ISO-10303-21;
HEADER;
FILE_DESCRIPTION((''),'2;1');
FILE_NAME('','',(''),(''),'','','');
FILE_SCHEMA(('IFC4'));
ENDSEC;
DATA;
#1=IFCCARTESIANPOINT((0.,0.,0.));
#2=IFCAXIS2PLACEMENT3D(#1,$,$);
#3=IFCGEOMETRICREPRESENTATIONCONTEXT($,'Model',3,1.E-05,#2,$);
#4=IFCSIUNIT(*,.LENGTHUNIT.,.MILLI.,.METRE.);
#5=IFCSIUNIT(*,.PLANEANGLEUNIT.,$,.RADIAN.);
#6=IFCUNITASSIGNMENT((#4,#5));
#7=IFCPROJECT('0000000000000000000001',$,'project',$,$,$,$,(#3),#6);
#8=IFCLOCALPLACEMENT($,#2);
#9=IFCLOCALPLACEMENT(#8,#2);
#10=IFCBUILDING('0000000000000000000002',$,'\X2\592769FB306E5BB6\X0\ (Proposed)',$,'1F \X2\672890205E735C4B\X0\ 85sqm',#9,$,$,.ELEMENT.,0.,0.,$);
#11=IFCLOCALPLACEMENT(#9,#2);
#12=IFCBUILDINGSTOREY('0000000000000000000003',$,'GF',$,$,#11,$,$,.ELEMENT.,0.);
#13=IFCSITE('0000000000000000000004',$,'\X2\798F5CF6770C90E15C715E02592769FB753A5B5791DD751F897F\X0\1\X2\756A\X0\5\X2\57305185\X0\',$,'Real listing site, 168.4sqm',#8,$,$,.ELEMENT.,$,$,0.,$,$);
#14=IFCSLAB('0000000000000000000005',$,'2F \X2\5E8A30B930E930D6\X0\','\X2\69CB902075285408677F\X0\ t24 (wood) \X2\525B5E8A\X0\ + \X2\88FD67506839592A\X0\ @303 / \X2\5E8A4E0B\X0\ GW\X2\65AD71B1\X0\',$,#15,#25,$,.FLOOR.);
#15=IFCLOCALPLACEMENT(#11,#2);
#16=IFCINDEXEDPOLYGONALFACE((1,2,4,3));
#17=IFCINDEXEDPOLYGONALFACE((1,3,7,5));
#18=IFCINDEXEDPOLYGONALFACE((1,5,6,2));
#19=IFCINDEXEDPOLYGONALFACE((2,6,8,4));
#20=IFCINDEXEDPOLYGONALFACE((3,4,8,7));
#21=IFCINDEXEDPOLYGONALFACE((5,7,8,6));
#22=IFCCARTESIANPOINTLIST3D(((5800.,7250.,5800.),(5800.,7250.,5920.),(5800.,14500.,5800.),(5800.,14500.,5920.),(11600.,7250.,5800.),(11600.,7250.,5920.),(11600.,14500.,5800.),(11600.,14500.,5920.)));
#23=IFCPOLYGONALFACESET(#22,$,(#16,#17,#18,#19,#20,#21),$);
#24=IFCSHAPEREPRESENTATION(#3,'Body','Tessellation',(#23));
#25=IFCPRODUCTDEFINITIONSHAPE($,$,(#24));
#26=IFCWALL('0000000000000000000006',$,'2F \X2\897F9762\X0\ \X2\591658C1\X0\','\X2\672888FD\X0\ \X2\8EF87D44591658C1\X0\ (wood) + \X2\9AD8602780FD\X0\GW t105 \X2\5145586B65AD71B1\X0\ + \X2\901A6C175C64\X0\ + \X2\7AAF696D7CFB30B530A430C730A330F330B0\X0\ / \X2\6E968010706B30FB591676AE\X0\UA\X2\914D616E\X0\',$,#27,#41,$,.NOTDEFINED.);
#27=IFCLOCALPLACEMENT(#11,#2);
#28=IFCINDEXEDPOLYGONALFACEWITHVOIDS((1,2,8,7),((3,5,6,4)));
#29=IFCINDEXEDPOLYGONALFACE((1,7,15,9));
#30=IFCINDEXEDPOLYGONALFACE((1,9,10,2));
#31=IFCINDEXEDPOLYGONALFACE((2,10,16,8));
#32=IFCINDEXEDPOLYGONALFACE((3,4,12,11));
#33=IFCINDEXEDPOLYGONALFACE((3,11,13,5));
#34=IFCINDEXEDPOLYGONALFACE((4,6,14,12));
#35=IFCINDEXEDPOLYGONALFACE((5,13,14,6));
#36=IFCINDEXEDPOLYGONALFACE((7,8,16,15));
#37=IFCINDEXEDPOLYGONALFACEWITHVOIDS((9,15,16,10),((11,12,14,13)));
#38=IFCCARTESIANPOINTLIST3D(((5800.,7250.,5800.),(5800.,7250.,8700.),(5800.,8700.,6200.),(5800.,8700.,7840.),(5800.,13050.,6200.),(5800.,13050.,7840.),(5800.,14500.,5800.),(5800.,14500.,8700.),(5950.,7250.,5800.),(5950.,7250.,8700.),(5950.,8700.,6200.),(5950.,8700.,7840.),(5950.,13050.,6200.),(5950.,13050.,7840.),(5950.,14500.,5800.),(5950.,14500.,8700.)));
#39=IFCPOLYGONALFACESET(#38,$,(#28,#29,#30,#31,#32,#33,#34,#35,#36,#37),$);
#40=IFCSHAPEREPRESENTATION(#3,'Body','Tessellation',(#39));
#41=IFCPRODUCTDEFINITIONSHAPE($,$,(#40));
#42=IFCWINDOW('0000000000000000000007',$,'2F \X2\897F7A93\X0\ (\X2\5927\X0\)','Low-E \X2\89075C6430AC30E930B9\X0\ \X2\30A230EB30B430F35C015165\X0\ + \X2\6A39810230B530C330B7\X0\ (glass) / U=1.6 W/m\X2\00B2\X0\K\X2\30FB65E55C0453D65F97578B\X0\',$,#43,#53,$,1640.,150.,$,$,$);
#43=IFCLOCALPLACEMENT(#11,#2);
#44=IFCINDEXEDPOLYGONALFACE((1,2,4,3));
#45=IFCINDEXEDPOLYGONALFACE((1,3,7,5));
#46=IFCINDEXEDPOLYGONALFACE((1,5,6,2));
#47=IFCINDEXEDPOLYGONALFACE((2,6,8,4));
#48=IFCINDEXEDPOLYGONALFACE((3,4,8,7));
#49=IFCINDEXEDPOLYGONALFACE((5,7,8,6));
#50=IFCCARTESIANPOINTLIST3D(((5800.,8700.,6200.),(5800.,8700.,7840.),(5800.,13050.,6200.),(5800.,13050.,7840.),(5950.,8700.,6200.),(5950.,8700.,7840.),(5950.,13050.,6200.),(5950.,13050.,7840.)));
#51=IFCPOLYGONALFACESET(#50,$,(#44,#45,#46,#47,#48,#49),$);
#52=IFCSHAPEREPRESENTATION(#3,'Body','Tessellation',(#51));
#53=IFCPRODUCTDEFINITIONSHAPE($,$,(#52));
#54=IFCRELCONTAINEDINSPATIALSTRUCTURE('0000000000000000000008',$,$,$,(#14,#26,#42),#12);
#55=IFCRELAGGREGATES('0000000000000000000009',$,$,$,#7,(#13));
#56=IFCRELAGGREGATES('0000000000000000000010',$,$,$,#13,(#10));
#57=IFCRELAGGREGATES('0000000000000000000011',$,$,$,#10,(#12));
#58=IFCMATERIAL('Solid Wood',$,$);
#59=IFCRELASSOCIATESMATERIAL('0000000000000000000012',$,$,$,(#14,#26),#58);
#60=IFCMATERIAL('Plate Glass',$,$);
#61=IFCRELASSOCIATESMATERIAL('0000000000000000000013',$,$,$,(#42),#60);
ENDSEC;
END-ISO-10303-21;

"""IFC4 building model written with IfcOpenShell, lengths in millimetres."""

from ifc_helpers import new_model, si_unit, frame, frame_2d, origin, place, context, project, spatial, rectangle, extrude, material, element, fill, save


model = new_model("IFC4")

# Units and contexts
model_context = context("Model", 3, precision=1e-05, world=origin())
ifc_project = project(units=[si_unit("LENGTHUNIT", "METRE", prefix="MILLI"), si_unit("PLANEANGLEUNIT", "RADIAN")], contexts=[model_context])

# Site, building, storey
site_placement = place(None, origin())
site = spatial("IfcSite", under=ifc_project, at=site_placement, Name="福島県郡山市大槻町字針生西1番5地内", ObjectType="Real listing site, 168.4sqm", CompositionType="ELEMENT", RefElevation=0.0)
building_placement = place(site_placement, origin())
building = spatial("IfcBuilding", under=site, at=building_placement, Name="大槻の家 (Proposed)", ObjectType="1F 木造平屋 85sqm", CompositionType="ELEMENT", ElevationOfRefHeight=0.0, ElevationOfTerrain=0.0)
storey_placement = place(building_placement, origin())
storey = spatial("IfcBuildingStorey", under=building, at=storey_placement, Name="GF", CompositionType="ELEMENT", Elevation=0.0)

# Slab
ifc_material_1 = material(Name="Solid Wood")
slab_placement = place(storey_placement, frame((2900.0, 3625.0, 2900.0)))
element("IfcSlab", 1, at=slab_placement, inside=storey, material=ifc_material_1, Name="2F 床スラブ", Description="構造用合板 t24 (wood) 剛床 + 製材根太 @303 / 床下 GW断熱", PredefinedType="FLOOR", context=model_context, shape_type="SweptSolid", body=[
    extrude(rectangle(XDim=5800.0, YDim=7250.0, at=frame_2d((2900.0, 3625.0))), frame((2900.0, 3625.0, 2900.0)), (0.0, 0.0, 1.0), 120.0),
])

# Shared definitions
ifc_material_2 = material(Name="Plate Glass")

# Wall, opening, window
wall_1_placement = place(storey_placement, frame((2900.0, 3625.0, 2900.0)))
wall_1 = element("IfcWall", 2, at=wall_1_placement, inside=storey, material=ifc_material_1, Name="2F 西面 外壁", Description="木製 軸組外壁 (wood) + 高性能GW t105 充填断熱 + 通気層 + 窯業系サイディング / 準耐火・外皮UA配慮", PredefinedType="NOTDEFINED", context=model_context, shape_type="SweptSolid", body=[
    extrude(rectangle(XDim=150.0, YDim=7250.0, at=frame_2d((75.0, 3625.0))), frame((2900.0, 3625.0, 2900.0)), (0.0, 0.0, 1.0), 2900.0),
])
opening_1_placement = place(storey_placement, frame((2900.0, 4350.0, 3100.0)))
opening_1 = element("IfcOpeningElement", 3, at=opening_1_placement, cuts=wall_1, PredefinedType="NOTDEFINED", context=model_context, shape_type="SweptSolid", body=[
    extrude(rectangle(XDim=150.0, YDim=4350.0, at=frame_2d((75.0, 2175.0))), frame((2900.0, 4350.0, 3100.0)), (0.0, 0.0, 1.0), 1640.0),
])
window_1_placement = place(storey_placement, frame((2900.0, 4350.0, 3100.0)))
window_1 = element("IfcWindow", 4, at=window_1_placement, inside=storey, material=ifc_material_2, Name="2F 西窓 (大)", Description="Low-E 複層ガラス アルゴン封入 + 樹脂サッシ (glass) / U=1.6 W/m²K・日射取得型", OverallHeight=1640.0, OverallWidth=150.0, context=model_context, shape_type="SweptSolid", body=[
    extrude(rectangle(XDim=150.0, YDim=4350.0, at=frame_2d((75.0, 2175.0))), frame((2900.0, 4350.0, 3100.0)), (0.0, 0.0, 1.0), 1640.0),
])
fill(opening_1, window_1)

save(model, "model.ifc")
